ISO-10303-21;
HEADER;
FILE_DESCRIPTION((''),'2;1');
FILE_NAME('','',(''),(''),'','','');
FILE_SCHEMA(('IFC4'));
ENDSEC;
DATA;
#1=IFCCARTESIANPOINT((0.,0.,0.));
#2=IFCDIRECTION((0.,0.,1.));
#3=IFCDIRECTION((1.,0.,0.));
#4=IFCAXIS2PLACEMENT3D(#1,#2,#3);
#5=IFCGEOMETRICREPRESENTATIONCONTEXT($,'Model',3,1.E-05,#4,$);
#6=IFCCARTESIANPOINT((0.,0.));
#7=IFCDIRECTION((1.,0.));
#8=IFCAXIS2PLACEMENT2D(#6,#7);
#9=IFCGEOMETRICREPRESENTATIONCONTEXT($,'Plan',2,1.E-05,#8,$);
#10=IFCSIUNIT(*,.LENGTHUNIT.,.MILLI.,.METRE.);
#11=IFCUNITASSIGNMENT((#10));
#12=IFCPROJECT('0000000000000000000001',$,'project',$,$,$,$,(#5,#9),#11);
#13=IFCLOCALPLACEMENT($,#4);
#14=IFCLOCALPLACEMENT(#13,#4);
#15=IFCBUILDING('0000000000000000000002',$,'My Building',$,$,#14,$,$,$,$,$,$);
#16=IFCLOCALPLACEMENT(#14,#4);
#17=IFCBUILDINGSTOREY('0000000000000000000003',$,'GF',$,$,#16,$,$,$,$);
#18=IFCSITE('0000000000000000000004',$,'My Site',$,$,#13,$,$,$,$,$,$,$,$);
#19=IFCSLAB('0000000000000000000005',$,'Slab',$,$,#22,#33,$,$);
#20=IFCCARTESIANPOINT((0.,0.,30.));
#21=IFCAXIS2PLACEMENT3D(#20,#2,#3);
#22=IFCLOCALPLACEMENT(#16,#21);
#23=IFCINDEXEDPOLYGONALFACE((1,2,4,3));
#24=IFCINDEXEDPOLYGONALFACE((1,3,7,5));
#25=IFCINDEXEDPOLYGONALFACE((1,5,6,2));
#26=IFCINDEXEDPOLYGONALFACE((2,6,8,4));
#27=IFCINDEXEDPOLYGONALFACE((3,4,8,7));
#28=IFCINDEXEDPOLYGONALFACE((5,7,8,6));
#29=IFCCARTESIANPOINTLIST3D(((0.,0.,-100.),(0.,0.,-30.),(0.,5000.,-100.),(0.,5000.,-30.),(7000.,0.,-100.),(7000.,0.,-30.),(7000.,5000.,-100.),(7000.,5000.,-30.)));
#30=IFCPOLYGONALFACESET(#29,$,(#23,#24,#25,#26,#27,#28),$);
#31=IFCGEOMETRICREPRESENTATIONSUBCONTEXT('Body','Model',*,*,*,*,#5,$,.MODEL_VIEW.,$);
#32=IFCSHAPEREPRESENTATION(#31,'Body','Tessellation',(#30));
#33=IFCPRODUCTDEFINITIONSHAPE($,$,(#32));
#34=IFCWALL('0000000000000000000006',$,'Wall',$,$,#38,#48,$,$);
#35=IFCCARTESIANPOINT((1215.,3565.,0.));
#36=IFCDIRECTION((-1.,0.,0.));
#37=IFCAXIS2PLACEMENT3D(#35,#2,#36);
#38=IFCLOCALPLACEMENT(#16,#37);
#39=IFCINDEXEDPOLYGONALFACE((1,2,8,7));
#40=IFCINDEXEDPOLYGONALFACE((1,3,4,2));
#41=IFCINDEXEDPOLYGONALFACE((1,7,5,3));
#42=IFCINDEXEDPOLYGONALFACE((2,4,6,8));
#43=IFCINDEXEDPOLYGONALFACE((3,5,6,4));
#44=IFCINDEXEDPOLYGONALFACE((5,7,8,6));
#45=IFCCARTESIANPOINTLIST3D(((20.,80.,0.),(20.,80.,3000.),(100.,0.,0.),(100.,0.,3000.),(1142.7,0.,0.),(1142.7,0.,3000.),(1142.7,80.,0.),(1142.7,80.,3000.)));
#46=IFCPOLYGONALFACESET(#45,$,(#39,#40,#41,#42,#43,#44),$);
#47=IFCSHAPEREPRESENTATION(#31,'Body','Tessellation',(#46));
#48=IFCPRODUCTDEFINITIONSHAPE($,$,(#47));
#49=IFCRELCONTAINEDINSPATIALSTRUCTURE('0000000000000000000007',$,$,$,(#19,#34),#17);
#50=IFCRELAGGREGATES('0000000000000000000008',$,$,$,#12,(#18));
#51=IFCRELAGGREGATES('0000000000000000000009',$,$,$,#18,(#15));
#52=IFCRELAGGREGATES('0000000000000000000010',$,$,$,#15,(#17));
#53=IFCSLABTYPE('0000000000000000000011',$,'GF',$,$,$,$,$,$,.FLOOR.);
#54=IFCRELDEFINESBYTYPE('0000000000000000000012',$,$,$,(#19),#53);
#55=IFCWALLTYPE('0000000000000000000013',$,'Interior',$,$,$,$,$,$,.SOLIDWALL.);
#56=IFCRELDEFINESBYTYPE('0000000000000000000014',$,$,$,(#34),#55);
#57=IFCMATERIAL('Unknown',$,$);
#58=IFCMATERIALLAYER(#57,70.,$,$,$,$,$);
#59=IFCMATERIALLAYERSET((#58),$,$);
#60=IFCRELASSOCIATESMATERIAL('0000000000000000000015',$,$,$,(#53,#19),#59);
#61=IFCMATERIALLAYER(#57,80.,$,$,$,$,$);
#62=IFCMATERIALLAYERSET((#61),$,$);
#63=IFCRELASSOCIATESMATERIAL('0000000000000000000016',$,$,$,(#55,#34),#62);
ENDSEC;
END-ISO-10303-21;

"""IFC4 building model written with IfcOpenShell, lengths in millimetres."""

from ifc_helpers import new_model, si_unit, frame, origin_with_axes, origin_2d_with_axis, place, context, subcontext, project, spatial, line, indexed_curve, outline, extrude, material, layer, layer_set, layer_usage, type_object, element, save


model = new_model("IFC4")

# Units and contexts
model_context = context("Model", 3, precision=1e-05, world=origin_with_axes())
plan_context = context("Plan", 2, precision=1e-05, world=origin_2d_with_axis())
body_context_1 = subcontext(model_context, "Body", "Model", "MODEL_VIEW")
ifc_project = project(units=[si_unit("LENGTHUNIT", "METRE", prefix="MILLI")], contexts=[model_context, plan_context])

# Site, building, storey
site_placement = place(None, origin_with_axes())
site = spatial("IfcSite", under=ifc_project, at=site_placement, Name="My Site")
building_placement = place(site_placement, origin_with_axes())
building = spatial("IfcBuilding", under=site, at=building_placement, Name="My Building")
storey_placement = place(building_placement, origin_with_axes())
storey = spatial("IfcBuildingStorey", under=building, at=storey_placement, Name="GF")

# Shared definitions
ifc_material = material(Name="Unknown")

# Slab
ifc_layer_1 = layer(ifc_material, 70.0)
ifc_layer_set_1 = layer_set([ifc_layer_1])
ifc_layer_usage_1 = layer_usage(ifc_layer_set_1, "AXIS3", "POSITIVE", -100.0)
slab_type_1 = type_object("IfcSlabType", Name="GF", PredefinedType="FLOOR", material=ifc_layer_set_1)
slab_1_placement = place(storey_placement, frame((0.0, 0.0, 30.0), z_axis=(0.0, 0.0, 1.0), x_axis=(1.0, 0.0, 0.0)))
element("IfcSlab", 1, at=slab_1_placement, inside=storey, type_object=slab_type_1, material=ifc_layer_usage_1, Name="Slab", context=body_context_1, shape_type="SweptSolid", body=[
    extrude(outline(indexed_curve([(0.0, 0.0), (7000.0, 0.0), (7000.0, 5000.0), (0.0, 5000.0), (0.0, 0.0)])), frame((0.0, 0.0, -100.0), z_axis=(0.0, 0.0, 1.0), x_axis=(1.0, 0.0, 0.0)), (0.0, 0.0, 1.0), 70.0),
])

# Shared definitions
ifc_layer_2 = layer(ifc_material, 80.0)
ifc_layer_set_2 = layer_set([ifc_layer_2])
wall_type_1 = type_object("IfcWallType", Name="Interior", PredefinedType="SOLIDWALL", material=ifc_layer_set_2)

# Wall
ifc_layer_usage_2 = layer_usage(ifc_layer_set_2, "AXIS2", "POSITIVE", 0.0)
wall_1_placement = place(storey_placement, frame((1215.0, 3565.0, 0.0), z_axis=(0.0, 0.0, 1.0), x_axis=(-1.0, 0.0, 0.0)))
element("IfcWall", 2, at=wall_1_placement, inside=storey, type_object=wall_type_1, material=ifc_layer_usage_2, Name="Wall", context=body_context_1, shape_type="SweptSolid", body=[
    extrude(outline(indexed_curve([(100.0, 0.0), (20.0, 80.0), (1142.7, 80.0), (1142.7, 0.0)], segments=[line(1, 2, 3, 4, 1)])), origin_with_axes(), (0.0, 0.0, 1.0), 3000.0),
])

save(model, "model.ifc")
